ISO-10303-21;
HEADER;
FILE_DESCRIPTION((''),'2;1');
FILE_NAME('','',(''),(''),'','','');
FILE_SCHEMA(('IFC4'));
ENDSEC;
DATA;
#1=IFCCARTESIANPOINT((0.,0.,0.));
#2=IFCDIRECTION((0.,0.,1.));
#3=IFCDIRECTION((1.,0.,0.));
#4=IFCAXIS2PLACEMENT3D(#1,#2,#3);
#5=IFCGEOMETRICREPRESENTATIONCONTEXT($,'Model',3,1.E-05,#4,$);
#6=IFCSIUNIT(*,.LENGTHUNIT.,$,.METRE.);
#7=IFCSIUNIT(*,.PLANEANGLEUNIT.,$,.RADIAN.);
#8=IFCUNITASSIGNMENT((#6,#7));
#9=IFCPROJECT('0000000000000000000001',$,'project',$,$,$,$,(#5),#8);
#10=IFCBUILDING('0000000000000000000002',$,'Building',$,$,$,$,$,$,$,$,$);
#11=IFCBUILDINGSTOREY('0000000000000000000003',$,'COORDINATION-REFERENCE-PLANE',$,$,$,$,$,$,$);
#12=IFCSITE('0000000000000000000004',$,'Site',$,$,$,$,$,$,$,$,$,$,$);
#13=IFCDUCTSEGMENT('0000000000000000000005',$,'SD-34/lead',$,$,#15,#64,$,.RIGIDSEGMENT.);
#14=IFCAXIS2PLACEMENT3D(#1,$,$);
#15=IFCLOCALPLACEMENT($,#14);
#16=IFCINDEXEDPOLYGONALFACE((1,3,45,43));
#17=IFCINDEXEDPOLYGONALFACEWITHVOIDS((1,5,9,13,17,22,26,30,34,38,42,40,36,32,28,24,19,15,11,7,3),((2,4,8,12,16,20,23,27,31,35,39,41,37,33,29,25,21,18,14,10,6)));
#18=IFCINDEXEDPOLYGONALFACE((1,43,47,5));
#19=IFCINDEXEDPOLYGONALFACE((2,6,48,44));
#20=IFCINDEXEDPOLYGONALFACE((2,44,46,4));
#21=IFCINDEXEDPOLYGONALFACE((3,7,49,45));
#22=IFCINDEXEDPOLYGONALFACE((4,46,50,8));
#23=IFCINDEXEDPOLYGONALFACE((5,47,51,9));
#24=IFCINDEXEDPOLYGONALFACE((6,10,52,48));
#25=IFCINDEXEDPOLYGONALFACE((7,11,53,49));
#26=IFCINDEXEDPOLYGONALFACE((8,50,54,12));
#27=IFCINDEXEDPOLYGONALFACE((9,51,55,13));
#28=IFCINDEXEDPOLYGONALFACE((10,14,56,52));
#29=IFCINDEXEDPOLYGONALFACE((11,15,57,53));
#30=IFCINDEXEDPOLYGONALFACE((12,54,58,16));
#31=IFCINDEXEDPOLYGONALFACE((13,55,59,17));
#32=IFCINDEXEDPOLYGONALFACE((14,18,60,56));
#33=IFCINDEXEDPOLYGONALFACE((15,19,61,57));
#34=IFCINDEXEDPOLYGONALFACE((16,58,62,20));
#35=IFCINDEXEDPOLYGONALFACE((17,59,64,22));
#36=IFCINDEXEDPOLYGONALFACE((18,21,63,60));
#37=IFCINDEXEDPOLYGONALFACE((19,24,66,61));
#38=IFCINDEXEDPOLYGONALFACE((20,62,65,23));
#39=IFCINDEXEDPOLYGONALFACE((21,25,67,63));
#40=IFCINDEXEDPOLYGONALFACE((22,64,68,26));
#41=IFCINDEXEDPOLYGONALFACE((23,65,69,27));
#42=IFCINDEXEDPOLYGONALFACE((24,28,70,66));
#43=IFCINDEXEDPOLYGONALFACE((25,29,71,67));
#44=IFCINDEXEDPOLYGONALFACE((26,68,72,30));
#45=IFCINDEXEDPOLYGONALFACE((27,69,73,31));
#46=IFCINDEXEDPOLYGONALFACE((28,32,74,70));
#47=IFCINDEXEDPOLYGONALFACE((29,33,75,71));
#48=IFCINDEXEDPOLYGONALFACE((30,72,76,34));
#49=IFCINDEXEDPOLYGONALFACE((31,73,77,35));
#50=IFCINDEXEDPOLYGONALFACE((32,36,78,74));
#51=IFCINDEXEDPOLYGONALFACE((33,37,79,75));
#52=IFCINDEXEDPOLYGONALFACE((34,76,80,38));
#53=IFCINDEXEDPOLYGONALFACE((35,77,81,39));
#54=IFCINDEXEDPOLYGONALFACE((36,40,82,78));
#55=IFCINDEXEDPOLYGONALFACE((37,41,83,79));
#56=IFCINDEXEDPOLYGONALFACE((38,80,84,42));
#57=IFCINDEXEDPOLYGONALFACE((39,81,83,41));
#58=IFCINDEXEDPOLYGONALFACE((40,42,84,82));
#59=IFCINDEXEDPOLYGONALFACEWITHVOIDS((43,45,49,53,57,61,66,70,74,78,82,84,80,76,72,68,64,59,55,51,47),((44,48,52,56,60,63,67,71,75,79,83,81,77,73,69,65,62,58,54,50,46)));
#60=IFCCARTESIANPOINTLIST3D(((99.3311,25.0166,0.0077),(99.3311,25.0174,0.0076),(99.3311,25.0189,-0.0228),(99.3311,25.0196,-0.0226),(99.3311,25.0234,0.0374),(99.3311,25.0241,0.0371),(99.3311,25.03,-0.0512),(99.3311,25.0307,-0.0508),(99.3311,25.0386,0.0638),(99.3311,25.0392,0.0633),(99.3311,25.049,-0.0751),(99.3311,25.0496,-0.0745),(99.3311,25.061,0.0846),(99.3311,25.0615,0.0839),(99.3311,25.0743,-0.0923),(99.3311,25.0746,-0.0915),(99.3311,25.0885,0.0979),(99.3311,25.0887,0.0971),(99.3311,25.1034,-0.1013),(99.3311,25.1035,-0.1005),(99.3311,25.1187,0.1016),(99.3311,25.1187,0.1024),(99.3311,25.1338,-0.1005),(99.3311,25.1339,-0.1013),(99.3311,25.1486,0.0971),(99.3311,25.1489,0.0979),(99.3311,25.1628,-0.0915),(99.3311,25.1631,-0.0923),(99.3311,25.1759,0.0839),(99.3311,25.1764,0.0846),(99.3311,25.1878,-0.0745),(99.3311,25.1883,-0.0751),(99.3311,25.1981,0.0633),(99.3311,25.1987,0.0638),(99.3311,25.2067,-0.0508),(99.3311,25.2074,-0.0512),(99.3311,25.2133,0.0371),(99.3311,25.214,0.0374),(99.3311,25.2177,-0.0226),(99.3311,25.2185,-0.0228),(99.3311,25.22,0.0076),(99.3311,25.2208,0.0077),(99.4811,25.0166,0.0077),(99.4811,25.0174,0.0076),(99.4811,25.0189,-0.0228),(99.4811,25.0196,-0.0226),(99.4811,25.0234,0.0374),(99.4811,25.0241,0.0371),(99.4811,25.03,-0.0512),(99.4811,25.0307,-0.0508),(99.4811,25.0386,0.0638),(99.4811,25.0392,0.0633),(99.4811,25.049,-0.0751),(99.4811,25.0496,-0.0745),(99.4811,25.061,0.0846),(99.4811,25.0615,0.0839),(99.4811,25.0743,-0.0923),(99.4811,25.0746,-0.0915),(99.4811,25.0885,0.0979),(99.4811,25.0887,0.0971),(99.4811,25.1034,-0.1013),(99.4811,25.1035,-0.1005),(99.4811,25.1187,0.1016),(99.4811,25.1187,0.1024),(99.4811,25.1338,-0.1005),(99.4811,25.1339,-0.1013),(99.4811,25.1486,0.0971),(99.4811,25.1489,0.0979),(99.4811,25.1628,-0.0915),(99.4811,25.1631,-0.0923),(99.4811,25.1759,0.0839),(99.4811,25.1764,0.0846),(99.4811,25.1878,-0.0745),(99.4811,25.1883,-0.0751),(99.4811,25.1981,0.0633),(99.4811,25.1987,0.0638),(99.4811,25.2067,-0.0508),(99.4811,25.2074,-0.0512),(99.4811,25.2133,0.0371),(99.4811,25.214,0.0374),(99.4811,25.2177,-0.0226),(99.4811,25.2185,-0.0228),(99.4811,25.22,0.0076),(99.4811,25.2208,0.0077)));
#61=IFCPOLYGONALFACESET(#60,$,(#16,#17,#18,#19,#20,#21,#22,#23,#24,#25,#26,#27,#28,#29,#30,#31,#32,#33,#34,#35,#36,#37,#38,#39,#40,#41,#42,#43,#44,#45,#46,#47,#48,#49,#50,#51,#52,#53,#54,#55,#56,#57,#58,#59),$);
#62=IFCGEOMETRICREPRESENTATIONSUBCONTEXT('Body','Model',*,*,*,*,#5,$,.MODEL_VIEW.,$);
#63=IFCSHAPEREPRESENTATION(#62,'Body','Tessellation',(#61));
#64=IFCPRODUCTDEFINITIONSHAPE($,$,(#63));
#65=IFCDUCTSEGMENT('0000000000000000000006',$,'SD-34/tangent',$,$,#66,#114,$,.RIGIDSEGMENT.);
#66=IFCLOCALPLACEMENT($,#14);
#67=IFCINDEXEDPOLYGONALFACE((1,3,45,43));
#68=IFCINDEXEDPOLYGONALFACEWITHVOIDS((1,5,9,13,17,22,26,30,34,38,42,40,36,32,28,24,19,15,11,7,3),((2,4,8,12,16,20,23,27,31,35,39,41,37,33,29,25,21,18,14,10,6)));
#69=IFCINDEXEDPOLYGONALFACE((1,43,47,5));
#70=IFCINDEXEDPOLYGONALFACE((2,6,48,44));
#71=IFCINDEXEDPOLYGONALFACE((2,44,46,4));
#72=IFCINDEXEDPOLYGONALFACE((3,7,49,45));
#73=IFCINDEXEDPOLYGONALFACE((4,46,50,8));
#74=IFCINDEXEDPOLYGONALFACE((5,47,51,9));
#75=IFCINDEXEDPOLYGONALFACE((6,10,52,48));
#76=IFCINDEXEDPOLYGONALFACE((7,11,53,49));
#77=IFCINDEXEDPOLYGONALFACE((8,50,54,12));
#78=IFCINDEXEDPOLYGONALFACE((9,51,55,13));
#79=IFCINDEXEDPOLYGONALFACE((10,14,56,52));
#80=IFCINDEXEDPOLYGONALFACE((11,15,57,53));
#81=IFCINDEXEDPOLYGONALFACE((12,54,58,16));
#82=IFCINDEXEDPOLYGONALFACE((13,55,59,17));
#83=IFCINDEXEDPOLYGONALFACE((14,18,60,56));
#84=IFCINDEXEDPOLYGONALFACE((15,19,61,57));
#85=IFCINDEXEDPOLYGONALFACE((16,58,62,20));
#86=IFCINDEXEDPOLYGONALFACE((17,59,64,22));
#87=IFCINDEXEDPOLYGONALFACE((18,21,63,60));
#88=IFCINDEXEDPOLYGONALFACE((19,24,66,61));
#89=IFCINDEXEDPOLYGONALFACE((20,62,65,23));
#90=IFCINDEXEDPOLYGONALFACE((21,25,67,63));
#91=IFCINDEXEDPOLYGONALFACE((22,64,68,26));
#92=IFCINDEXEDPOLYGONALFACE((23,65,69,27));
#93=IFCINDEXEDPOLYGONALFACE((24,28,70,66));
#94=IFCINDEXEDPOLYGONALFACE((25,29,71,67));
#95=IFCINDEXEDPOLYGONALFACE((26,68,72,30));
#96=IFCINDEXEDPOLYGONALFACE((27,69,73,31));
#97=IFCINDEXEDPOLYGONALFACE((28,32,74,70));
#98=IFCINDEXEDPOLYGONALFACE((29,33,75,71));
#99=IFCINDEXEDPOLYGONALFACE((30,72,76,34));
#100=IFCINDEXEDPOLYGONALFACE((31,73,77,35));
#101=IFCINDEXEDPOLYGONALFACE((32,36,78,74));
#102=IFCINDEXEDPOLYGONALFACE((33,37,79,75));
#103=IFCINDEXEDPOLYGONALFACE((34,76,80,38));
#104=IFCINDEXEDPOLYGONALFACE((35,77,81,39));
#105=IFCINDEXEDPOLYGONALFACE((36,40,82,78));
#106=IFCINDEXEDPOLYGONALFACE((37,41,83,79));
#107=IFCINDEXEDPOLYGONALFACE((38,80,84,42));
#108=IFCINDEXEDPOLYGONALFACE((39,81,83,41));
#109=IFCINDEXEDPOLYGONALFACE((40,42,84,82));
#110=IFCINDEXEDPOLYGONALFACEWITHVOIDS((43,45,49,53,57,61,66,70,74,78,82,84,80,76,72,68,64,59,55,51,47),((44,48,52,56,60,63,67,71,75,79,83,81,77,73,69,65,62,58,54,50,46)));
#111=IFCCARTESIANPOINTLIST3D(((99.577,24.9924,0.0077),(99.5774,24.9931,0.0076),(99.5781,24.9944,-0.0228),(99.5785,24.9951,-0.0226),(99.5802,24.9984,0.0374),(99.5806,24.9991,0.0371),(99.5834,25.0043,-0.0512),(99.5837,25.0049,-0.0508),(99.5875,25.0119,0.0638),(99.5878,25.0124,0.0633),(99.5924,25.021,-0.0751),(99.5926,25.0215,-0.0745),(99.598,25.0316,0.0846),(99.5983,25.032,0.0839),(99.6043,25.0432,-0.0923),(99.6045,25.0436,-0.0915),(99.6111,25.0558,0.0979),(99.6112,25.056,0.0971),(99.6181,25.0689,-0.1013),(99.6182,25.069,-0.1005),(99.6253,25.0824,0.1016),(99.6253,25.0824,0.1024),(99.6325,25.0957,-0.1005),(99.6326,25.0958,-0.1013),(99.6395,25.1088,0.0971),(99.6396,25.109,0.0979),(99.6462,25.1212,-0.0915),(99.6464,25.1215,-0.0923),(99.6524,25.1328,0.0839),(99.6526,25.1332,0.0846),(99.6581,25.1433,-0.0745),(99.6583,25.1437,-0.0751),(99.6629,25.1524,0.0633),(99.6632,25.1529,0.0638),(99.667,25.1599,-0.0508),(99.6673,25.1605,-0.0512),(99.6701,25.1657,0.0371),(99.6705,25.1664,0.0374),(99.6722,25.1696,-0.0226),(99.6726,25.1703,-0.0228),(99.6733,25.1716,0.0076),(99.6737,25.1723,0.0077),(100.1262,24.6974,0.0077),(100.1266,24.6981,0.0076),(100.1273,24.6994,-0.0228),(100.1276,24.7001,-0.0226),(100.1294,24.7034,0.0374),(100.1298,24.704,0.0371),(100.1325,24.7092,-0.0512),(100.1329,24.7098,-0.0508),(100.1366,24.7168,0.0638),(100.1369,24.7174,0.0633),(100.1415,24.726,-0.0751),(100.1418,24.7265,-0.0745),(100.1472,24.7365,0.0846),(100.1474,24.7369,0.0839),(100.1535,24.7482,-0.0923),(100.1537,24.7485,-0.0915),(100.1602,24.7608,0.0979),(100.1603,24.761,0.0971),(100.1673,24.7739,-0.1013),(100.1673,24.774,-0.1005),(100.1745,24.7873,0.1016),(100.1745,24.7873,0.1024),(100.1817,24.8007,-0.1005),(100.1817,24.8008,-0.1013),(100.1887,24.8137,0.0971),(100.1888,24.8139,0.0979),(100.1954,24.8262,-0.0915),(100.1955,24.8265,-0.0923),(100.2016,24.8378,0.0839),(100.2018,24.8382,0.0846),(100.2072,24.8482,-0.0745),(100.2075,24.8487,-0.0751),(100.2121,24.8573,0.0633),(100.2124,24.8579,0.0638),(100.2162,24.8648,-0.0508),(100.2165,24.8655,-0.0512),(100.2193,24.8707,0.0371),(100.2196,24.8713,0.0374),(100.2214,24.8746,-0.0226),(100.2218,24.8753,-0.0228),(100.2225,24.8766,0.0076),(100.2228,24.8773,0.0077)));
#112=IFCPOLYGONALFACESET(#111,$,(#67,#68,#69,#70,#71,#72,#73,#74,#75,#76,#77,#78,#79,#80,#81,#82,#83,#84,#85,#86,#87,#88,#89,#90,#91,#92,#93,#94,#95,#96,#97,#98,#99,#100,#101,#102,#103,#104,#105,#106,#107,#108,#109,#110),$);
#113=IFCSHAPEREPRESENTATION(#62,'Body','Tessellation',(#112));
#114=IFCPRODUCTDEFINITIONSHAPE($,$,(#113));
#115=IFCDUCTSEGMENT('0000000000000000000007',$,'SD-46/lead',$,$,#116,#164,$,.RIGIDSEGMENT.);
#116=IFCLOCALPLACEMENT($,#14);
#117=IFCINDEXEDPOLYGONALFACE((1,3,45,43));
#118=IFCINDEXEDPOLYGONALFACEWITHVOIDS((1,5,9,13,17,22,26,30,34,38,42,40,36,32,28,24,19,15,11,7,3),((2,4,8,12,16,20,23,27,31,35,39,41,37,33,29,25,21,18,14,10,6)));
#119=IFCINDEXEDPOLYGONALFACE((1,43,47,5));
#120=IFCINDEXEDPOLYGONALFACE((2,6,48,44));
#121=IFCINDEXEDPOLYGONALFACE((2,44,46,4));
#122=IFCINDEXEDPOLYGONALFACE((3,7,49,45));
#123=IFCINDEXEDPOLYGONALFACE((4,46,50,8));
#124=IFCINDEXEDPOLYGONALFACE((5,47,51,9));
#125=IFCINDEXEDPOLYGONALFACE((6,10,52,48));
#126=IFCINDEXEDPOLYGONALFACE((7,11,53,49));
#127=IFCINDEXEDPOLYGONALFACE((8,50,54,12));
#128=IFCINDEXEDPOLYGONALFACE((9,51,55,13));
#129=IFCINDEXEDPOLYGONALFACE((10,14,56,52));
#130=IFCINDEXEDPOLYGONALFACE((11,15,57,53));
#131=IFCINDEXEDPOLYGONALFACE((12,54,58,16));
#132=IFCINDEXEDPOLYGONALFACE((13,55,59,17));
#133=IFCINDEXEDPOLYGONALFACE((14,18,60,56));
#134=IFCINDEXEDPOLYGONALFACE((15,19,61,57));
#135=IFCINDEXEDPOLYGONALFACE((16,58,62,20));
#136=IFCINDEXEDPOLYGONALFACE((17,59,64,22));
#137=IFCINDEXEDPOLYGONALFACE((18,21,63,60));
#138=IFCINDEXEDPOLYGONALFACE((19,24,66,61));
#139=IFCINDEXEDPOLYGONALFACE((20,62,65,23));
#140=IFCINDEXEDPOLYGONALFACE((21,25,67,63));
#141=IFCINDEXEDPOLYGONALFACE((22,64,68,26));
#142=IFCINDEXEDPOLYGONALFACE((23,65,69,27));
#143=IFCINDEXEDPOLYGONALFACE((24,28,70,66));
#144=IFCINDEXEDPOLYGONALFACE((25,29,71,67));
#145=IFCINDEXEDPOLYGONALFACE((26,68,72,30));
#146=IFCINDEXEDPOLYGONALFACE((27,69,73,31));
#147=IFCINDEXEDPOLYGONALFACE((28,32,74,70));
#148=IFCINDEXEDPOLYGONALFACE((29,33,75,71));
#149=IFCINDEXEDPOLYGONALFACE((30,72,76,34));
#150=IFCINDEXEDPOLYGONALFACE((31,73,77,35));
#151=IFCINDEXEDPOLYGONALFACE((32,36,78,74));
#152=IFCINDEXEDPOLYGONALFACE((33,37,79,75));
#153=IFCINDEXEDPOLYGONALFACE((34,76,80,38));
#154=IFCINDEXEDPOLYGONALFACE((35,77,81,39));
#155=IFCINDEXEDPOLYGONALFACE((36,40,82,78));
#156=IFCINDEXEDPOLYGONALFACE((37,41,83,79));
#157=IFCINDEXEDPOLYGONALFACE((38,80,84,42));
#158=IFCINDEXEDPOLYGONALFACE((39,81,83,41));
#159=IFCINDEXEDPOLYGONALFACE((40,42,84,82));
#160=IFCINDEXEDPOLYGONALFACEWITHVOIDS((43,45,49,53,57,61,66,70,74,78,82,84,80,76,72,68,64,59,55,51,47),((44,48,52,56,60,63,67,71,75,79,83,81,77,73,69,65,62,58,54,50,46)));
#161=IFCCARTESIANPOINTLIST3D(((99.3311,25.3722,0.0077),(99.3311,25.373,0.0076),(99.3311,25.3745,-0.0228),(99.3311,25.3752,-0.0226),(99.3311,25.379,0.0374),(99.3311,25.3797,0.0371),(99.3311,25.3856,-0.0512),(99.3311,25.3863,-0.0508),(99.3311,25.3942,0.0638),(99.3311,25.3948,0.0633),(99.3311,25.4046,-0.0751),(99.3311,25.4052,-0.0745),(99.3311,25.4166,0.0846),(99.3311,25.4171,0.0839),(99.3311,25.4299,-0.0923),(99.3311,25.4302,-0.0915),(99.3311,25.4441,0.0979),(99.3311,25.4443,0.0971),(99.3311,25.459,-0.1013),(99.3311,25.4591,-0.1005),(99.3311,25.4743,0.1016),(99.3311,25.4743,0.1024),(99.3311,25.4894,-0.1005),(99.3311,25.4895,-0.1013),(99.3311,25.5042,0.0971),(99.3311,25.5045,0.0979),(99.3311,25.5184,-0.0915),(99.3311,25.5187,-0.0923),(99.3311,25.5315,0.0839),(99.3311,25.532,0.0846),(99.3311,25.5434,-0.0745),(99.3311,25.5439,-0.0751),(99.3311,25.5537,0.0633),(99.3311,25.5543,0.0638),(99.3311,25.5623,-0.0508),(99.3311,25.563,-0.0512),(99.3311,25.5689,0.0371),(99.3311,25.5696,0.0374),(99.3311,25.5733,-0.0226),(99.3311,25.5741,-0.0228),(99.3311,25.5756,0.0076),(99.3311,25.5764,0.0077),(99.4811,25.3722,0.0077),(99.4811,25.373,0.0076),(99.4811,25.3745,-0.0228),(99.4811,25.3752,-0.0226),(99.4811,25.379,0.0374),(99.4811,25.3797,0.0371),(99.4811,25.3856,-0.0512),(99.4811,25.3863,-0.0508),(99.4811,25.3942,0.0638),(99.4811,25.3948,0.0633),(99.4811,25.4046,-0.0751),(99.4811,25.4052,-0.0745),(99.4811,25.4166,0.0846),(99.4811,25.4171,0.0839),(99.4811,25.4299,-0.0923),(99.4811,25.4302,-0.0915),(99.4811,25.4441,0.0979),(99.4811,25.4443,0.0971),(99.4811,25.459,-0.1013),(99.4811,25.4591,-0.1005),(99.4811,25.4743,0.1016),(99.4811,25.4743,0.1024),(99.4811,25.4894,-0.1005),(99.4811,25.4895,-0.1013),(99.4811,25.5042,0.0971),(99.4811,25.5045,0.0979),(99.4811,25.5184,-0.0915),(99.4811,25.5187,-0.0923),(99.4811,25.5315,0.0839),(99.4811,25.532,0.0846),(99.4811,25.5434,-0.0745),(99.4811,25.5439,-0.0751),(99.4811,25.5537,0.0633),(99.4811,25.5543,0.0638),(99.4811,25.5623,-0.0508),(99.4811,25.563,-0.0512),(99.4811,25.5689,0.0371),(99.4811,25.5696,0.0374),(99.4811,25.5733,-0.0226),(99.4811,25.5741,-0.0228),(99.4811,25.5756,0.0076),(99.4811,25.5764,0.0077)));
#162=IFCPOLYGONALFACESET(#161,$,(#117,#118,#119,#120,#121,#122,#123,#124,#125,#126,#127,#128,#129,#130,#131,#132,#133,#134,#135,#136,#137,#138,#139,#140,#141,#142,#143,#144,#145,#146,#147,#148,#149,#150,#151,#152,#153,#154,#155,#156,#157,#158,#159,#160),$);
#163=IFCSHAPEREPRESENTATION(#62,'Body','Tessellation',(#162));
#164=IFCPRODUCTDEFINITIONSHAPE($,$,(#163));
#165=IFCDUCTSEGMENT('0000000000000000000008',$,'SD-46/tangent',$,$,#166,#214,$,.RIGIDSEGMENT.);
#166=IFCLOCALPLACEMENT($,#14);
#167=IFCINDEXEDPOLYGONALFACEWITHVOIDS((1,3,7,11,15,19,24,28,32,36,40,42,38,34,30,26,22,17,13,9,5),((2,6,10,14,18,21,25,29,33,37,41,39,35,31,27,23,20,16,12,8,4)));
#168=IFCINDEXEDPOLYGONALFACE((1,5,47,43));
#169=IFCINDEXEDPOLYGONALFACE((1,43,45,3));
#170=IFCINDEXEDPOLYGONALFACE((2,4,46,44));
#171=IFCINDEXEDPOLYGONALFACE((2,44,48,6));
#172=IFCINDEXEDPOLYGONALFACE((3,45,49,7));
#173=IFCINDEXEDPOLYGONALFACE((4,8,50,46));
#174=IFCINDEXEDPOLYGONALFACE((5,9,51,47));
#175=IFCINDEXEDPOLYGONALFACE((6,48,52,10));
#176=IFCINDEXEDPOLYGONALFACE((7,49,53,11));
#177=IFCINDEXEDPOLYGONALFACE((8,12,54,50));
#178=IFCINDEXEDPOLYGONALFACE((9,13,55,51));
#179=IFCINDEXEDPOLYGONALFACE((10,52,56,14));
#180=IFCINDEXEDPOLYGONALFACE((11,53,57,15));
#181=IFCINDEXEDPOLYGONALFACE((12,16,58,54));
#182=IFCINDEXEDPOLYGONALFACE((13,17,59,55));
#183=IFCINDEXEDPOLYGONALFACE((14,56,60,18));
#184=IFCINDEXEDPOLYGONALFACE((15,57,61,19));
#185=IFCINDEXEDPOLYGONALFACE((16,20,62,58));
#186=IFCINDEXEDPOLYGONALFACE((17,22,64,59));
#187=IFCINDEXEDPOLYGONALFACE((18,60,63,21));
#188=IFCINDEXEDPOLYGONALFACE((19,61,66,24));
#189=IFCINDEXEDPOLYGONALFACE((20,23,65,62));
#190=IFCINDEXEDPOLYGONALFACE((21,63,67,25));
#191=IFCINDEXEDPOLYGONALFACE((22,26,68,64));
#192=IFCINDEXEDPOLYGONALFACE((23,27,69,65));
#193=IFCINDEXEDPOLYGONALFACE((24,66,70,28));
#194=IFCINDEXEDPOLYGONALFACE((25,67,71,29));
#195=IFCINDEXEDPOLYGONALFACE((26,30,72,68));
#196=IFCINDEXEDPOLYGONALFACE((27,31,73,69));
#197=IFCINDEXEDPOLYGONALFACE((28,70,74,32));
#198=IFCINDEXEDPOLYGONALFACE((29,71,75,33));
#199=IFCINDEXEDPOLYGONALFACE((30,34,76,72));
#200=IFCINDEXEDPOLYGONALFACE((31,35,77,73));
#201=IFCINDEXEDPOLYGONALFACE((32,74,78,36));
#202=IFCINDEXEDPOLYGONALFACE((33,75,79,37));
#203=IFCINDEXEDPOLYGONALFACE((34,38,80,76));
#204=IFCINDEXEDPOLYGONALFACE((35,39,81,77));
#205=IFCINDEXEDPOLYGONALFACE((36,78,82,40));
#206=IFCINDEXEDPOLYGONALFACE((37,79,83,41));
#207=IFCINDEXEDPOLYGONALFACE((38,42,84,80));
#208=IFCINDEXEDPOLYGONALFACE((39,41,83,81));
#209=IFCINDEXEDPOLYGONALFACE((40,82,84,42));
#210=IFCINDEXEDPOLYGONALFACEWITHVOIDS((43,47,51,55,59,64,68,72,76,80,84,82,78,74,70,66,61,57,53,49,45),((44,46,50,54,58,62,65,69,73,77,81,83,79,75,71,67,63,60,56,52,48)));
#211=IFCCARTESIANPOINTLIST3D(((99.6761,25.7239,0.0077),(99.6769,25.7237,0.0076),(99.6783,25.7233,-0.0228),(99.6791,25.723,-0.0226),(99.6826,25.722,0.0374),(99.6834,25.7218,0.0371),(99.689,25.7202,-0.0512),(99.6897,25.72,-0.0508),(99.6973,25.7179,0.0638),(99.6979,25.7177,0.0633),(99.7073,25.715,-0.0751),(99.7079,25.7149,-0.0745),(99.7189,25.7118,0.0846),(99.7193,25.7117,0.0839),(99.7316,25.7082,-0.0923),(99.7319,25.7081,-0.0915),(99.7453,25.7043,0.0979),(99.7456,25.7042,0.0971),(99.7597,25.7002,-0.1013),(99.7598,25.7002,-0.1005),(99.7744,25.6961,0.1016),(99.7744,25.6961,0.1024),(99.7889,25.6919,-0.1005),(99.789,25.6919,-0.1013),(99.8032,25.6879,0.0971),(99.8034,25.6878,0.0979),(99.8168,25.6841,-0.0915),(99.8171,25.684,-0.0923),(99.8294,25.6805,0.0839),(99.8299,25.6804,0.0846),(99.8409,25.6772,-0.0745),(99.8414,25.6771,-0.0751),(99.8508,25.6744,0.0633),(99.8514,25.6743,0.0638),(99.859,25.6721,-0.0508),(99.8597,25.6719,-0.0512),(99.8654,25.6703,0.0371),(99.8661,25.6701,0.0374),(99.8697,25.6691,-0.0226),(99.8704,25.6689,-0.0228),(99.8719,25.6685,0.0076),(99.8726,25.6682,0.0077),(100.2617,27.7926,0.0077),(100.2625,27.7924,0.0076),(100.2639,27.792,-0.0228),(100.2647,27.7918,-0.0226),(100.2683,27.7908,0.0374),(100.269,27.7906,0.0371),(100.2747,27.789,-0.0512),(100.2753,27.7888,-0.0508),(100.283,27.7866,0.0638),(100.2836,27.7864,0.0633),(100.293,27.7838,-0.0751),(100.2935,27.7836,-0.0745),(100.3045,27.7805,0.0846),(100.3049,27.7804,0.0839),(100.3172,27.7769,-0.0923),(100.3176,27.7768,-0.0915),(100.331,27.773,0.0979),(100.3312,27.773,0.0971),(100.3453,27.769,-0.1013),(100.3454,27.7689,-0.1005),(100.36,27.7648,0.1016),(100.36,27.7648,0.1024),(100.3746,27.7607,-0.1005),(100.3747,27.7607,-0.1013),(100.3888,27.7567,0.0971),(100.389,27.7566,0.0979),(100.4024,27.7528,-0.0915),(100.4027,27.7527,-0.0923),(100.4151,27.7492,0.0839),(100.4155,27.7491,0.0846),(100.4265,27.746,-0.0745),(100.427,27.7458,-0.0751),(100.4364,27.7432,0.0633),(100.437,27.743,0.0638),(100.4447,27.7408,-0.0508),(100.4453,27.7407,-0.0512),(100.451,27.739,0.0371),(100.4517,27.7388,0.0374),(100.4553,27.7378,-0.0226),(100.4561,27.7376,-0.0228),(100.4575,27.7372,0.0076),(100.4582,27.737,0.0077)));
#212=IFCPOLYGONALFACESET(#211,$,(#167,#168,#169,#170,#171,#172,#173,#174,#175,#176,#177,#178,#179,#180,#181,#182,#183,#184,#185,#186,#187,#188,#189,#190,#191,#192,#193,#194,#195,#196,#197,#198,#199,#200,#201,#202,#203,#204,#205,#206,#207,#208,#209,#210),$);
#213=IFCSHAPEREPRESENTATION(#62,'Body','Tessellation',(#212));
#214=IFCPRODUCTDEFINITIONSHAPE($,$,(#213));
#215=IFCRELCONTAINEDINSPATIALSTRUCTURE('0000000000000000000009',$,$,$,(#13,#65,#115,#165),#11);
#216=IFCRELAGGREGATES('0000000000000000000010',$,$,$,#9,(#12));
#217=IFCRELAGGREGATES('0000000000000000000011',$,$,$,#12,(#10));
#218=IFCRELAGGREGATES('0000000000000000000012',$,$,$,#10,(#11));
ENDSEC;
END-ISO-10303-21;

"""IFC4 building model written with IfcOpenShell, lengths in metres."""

from ifc_helpers import new_model, si_unit, frame, origin_with_axes, place, context, subcontext, project, spatial, hollow_circle, extrude, element, save


model = new_model("IFC4")

# Units and contexts
model_context = context("Model", 3, precision=1e-05, world=origin_with_axes())
body_context_1 = subcontext(model_context, "Body", "Model", "MODEL_VIEW")
ifc_project = project(units=[si_unit("LENGTHUNIT", "METRE"), si_unit("PLANEANGLEUNIT", "RADIAN")], contexts=[model_context])

# Site, building, storey
site = spatial("IfcSite", under=ifc_project, Name="Site")
building = spatial("IfcBuilding", under=site, Name="Building")
storey = spatial("IfcBuildingStorey", under=building, Name="COORDINATION-REFERENCE-PLANE")

# Duct segment
duct_segment_1_placement = place(None, frame((99.3311, 25.1187, 0.0), z_axis=(1.0, 0.0, 0.0), x_axis=(0.0, 0.0, 1.0)))
element("IfcDuctSegment", 1, at=duct_segment_1_placement, inside=storey, Name="SD-34/lead", PredefinedType="RIGIDSEGMENT", context=body_context_1, shape_type="SweptSolid", body=[
    extrude(hollow_circle(Radius=0.1024, WallThickness=0.0008), origin_with_axes(), (0.0, 0.0, 1.0), 0.15),
])

# Duct segment
duct_segment_2_placement = place(None, frame((99.6253, 25.0824, 0.0), z_axis=(0.880912, -0.473279, 0.0), x_axis=(0.0, 0.0, 1.0)))
element("IfcDuctSegment", 2, at=duct_segment_2_placement, inside=storey, Name="SD-34/tangent", PredefinedType="RIGIDSEGMENT", context=body_context_1, shape_type="SweptSolid", body=[
    extrude(hollow_circle(Radius=0.1024, WallThickness=0.0008), origin_with_axes(), (0.0, 0.0, 1.0), 0.6234),
])

# Duct segment
duct_segment_3_placement = place(None, frame((99.3311, 25.4743, 0.0), z_axis=(1.0, 0.0, 0.0), x_axis=(0.0, 0.0, 1.0)))
element("IfcDuctSegment", 3, at=duct_segment_3_placement, inside=storey, Name="SD-46/lead", PredefinedType="RIGIDSEGMENT", context=body_context_1, shape_type="SweptSolid", body=[
    extrude(hollow_circle(Radius=0.1024, WallThickness=0.0008), origin_with_axes(), (0.0, 0.0, 1.0), 0.15),
])

# Duct segment
duct_segment_4_placement = place(None, frame((99.7744, 25.6961, 0.0), z_axis=(0.272381, 0.96219, 0.0), x_axis=(0.0, 0.0, 1.0)))
element("IfcDuctSegment", 4, at=duct_segment_4_placement, inside=storey, Name="SD-46/tangent", PredefinedType="RIGIDSEGMENT", context=body_context_1, shape_type="SweptSolid", body=[
    extrude(hollow_circle(Radius=0.1024, WallThickness=0.0008), origin_with_axes(), (0.0, 0.0, 1.0), 2.15),
])

save(model, "model.ifc")
